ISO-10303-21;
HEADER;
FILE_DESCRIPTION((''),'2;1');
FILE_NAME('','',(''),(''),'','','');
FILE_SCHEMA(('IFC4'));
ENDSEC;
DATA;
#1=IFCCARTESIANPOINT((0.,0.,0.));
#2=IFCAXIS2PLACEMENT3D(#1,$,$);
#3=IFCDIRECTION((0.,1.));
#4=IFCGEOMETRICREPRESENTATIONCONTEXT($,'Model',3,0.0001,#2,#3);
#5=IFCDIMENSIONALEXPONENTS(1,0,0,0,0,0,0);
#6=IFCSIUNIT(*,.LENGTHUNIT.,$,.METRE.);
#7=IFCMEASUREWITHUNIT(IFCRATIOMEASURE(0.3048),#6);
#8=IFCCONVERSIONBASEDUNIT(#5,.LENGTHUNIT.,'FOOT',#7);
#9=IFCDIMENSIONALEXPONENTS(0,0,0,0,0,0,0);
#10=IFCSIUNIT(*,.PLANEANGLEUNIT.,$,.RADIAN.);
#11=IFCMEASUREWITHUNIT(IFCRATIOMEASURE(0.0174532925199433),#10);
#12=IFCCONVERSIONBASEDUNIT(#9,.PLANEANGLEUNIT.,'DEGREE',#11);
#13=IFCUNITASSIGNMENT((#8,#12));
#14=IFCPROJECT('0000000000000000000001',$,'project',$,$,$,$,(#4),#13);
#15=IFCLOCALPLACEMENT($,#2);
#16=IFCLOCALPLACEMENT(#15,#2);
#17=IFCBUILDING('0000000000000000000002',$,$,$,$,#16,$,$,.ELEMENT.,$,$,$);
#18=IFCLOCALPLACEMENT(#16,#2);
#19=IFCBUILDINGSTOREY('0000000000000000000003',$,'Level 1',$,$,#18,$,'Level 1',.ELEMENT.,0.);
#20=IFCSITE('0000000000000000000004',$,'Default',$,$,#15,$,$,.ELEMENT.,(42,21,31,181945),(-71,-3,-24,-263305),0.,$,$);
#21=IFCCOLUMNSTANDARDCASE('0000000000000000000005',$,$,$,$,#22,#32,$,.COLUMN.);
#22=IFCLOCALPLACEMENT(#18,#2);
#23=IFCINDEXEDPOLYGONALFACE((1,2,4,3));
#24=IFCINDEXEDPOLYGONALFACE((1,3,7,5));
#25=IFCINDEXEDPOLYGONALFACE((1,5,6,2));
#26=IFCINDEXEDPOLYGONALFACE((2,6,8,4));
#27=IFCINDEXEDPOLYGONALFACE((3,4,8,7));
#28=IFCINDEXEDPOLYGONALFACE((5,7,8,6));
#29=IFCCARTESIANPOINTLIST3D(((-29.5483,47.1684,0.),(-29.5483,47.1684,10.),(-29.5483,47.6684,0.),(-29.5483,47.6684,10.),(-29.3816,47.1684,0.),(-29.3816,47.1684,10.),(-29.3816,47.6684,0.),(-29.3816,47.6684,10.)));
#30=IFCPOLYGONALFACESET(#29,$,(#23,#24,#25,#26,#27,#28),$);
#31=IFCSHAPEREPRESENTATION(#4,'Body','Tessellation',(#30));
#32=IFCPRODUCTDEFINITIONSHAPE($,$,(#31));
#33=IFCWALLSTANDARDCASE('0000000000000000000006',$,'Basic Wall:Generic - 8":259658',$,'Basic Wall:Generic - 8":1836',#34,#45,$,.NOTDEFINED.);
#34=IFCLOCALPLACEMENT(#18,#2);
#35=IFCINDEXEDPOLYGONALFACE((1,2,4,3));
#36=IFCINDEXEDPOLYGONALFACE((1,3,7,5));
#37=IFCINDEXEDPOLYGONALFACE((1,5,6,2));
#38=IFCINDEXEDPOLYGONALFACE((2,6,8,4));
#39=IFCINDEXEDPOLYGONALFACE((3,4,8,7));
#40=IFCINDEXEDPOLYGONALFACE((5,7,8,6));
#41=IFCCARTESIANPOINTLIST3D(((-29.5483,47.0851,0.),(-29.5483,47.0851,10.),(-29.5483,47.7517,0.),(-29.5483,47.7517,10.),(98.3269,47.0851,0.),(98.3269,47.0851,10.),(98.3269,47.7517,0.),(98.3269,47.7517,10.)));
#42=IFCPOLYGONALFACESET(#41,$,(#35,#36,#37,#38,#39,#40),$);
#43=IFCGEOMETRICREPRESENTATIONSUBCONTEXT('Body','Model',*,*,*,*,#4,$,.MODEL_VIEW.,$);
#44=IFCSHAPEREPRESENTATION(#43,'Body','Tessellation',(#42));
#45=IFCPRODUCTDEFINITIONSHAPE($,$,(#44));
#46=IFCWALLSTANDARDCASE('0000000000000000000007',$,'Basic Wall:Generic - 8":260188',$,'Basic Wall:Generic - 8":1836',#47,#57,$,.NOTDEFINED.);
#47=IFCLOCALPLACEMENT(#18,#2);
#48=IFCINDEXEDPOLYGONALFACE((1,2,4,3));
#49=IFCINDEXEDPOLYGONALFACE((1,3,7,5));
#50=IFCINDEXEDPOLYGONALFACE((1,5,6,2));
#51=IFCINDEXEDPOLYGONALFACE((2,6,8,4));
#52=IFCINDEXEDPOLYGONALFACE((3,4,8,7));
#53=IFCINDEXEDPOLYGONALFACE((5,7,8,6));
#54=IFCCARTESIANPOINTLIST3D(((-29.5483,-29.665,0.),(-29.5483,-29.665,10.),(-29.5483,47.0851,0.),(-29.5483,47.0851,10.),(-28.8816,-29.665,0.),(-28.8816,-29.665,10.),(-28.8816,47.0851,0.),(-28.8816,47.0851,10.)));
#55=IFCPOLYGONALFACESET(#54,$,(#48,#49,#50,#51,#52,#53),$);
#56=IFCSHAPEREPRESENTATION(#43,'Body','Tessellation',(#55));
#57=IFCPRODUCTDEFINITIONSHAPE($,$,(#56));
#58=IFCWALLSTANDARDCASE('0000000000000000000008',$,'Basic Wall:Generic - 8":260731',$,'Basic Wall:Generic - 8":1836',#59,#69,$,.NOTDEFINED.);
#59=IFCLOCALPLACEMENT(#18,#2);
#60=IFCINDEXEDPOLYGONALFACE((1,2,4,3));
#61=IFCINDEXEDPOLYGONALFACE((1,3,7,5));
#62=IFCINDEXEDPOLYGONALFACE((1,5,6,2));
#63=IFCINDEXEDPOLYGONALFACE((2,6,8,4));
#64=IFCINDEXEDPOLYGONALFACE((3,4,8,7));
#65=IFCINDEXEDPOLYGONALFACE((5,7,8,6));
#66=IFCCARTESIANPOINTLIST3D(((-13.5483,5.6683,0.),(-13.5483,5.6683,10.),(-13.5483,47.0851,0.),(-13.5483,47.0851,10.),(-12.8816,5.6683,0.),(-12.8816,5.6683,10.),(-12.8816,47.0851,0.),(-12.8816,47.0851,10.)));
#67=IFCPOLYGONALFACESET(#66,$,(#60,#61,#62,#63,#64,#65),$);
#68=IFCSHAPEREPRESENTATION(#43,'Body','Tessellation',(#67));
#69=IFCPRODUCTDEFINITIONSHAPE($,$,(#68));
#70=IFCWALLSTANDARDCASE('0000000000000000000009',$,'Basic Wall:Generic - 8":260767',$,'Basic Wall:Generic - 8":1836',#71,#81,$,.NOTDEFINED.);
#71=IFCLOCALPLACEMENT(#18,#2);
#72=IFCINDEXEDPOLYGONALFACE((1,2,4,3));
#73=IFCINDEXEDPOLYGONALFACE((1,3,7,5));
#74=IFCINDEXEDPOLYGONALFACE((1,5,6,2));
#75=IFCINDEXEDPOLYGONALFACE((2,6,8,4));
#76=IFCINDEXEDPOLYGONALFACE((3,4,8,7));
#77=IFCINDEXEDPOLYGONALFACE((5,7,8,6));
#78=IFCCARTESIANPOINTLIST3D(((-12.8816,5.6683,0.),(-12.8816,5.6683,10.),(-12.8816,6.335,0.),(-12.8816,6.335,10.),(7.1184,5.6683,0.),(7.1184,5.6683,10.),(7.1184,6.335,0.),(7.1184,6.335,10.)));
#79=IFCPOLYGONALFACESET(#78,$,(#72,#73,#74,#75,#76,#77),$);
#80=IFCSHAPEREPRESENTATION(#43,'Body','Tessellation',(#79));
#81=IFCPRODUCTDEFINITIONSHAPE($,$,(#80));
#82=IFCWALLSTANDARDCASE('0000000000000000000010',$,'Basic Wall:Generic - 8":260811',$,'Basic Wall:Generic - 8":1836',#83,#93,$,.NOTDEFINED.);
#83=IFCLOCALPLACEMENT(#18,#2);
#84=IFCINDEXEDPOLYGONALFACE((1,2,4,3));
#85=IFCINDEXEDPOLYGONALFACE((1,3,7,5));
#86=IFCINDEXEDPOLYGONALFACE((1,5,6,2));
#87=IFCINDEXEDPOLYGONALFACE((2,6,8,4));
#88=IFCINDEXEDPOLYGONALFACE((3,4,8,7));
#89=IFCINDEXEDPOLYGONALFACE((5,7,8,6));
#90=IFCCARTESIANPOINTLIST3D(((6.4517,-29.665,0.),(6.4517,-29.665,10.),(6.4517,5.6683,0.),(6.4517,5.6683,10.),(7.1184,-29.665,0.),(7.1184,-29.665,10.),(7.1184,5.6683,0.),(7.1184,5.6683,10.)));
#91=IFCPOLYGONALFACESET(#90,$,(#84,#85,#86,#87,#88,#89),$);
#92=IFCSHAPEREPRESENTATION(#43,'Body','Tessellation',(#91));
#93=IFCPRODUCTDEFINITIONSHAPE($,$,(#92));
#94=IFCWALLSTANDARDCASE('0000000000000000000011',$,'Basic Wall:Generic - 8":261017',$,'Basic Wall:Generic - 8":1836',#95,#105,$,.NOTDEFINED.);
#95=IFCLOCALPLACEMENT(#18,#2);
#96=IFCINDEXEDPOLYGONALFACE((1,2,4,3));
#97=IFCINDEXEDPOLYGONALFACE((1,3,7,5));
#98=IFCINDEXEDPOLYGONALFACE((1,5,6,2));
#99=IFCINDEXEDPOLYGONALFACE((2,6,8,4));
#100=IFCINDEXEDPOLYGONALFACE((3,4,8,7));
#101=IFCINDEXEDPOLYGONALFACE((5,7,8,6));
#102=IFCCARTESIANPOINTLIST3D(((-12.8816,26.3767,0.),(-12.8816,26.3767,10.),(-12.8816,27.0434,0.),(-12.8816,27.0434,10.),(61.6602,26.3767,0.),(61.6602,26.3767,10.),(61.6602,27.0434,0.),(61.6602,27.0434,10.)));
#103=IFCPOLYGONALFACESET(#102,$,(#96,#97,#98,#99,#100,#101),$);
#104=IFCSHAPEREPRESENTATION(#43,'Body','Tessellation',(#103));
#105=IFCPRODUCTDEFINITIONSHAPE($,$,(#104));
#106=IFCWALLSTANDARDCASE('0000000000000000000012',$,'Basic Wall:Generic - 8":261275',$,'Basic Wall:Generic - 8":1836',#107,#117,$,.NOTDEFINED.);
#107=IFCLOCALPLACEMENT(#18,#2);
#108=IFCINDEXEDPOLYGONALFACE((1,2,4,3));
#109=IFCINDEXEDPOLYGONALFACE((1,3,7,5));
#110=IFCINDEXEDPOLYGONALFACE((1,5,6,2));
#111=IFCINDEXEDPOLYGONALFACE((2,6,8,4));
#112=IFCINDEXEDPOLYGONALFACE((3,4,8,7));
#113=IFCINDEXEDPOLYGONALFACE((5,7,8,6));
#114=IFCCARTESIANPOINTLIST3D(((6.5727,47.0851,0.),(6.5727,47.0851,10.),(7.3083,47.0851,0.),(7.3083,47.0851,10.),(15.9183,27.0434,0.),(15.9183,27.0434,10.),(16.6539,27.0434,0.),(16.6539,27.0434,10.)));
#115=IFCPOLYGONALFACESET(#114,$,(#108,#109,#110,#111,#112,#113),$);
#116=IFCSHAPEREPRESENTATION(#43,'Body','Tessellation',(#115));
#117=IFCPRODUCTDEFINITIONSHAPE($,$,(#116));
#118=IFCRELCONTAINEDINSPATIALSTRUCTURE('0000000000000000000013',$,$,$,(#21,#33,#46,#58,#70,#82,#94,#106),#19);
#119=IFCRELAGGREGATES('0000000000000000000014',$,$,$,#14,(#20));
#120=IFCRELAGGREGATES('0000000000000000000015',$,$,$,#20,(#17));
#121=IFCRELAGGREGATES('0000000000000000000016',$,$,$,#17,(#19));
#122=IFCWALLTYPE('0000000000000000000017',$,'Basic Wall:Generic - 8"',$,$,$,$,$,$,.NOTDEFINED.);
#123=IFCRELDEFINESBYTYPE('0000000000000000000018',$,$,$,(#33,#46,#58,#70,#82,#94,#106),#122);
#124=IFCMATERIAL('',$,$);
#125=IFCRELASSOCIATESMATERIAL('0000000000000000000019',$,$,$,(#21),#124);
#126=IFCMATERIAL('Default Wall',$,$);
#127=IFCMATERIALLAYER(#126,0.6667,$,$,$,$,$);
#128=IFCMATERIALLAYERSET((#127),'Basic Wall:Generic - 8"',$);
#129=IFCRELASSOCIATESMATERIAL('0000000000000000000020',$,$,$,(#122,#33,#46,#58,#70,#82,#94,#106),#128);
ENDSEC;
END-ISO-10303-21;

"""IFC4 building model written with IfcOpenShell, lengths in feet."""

from ifc_helpers import new_model, entity, si_unit, converted_unit, direction, frame, frame_2d, origin, place, context, subcontext, project, spatial, polyline, rectangle, outline, extrude, material, layer, layer_set, layer_usage, type_object, element, save


model = new_model("IFC4")

# Units and contexts
model_context = context("Model", 3, precision=0.0001, world=origin(), true_north=direction((0.0, 1.0)))
body_context = subcontext(model_context, "Body", "Model", "MODEL_VIEW")
ifc_project = project(units=[converted_unit("LENGTHUNIT", "FOOT", entity("IfcRatioMeasure", 0.3048), si_unit("LENGTHUNIT", "METRE"), dimensions=[1, 0, 0, 0, 0, 0, 0]), converted_unit("PLANEANGLEUNIT", "DEGREE", entity("IfcRatioMeasure", 0.0174532925199433), si_unit("PLANEANGLEUNIT", "RADIAN"), dimensions=[0, 0, 0, 0, 0, 0, 0])], contexts=[model_context])

# Site, building, storey
site_placement = place(None, origin())
site = spatial("IfcSite", under=ifc_project, at=site_placement, Name="Default", CompositionType="ELEMENT", RefLatitude=(42, 21, 31, 181945), RefLongitude=(-71, -3, -24, -263305), RefElevation=0.0)
building_placement = place(site_placement, origin())
building = spatial("IfcBuilding", under=site, at=building_placement, CompositionType="ELEMENT")
storey_placement = place(building_placement, origin())
storey = spatial("IfcBuildingStorey", under=building, at=storey_placement, Name="Level 1", LongName="Level 1", CompositionType="ELEMENT", Elevation=0.0)

# Column
ifc_material_1 = material(Name="")
wall_1_placement = place(storey_placement, frame((-29.5483, 47.4184, 0.0)))
for number, where, z_axis, x_axis in (
    (1, (0.0833, 0.0, 0.0), (0.0, 0.0, 1.0), (1.0, 0.0, 0.0)),
):
    element("IfcColumnStandardCase", number, at=place(wall_1_placement, frame(where, z_axis=z_axis, x_axis=x_axis)), inside=storey, material=ifc_material_1, PredefinedType="COLUMN", context=model_context, shape_type="SweptSolid", body=[
        extrude(rectangle(XDim=0.1667, YDim=0.5), origin(), (0.0, 0.0, 1.0), 10.0),
    ])

# Walls
ifc_material_2 = material(Name="Default Wall")
ifc_layer = layer(ifc_material_2, 0.6667)
ifc_layer_set = layer_set([ifc_layer], Name="Basic Wall:Generic - 8\"")
ifc_layer_usage_1 = layer_usage(ifc_layer_set, "AXIS2", "NEGATIVE", 0.3333)
wall_type = type_object("IfcWallType", Name="Basic Wall:Generic - 8\"", PredefinedType="NOTDEFINED", material=ifc_layer_set)
element("IfcWallStandardCase", 2, at=wall_1_placement, inside=storey, type_object=wall_type, material=ifc_layer_usage_1, Name="Basic Wall:Generic - 8\":259658", ObjectType="Basic Wall:Generic - 8\":1836", PredefinedType="NOTDEFINED", context=body_context, shape_type="SweptSolid", body=[
    extrude(rectangle(XDim=127.8752, YDim=0.6667, at=frame_2d((63.9376, 0.0), x_axis=(-1.0, 0.0))), origin(), (0.0, 0.0, 1.0), 10.0),
])
ifc_layer_usage_2 = layer_usage(ifc_layer_set, "AXIS2", "NEGATIVE", 0.3333)
wall_2_placement = place(storey_placement, frame((-29.215, 47.0851, 0.0), z_axis=(0.0, 0.0, 1.0), x_axis=(0.0, -1.0, 0.0)))
element("IfcWallStandardCase", 3, at=wall_2_placement, inside=storey, type_object=wall_type, material=ifc_layer_usage_2, Name="Basic Wall:Generic - 8\":260188", ObjectType="Basic Wall:Generic - 8\":1836", PredefinedType="NOTDEFINED", context=body_context, shape_type="SweptSolid", body=[
    extrude(rectangle(XDim=76.7501, YDim=0.6667, at=frame_2d((38.375, 0.0), x_axis=(-1.0, 0.0))), origin(), (0.0, 0.0, 1.0), 10.0),
])
ifc_layer_usage_3 = layer_usage(ifc_layer_set, "AXIS2", "NEGATIVE", 0.3333)
wall_3_placement = place(storey_placement, frame((-13.215, 47.0851, 0.0), z_axis=(0.0, 0.0, 1.0), x_axis=(0.0, -1.0, 0.0)))
element("IfcWallStandardCase", 4, at=wall_3_placement, inside=storey, type_object=wall_type, material=ifc_layer_usage_3, Name="Basic Wall:Generic - 8\":260731", ObjectType="Basic Wall:Generic - 8\":1836", PredefinedType="NOTDEFINED", context=body_context, shape_type="SweptSolid", body=[
    extrude(rectangle(XDim=41.4167, YDim=0.6667, at=frame_2d((20.7084, 0.0), x_axis=(-1.0, 0.0))), origin(), (0.0, 0.0, 1.0), 10.0),
])
ifc_layer_usage_4 = layer_usage(ifc_layer_set, "AXIS2", "NEGATIVE", 0.3333)
wall_4_placement = place(storey_placement, frame((-12.8816, 6.0017, 0.0)))
element("IfcWallStandardCase", 5, at=wall_4_placement, inside=storey, type_object=wall_type, material=ifc_layer_usage_4, Name="Basic Wall:Generic - 8\":260767", ObjectType="Basic Wall:Generic - 8\":1836", PredefinedType="NOTDEFINED", context=body_context, shape_type="SweptSolid", body=[
    extrude(rectangle(XDim=20.0, YDim=0.6667, at=frame_2d((10.0, 0.0), x_axis=(-1.0, 0.0))), origin(), (0.0, 0.0, 1.0), 10.0),
])
ifc_layer_usage_5 = layer_usage(ifc_layer_set, "AXIS2", "NEGATIVE", 0.3333)
wall_5_placement = place(storey_placement, frame((6.785, 5.6683, 0.0), z_axis=(0.0, 0.0, 1.0), x_axis=(0.0, -1.0, 0.0)))
element("IfcWallStandardCase", 6, at=wall_5_placement, inside=storey, type_object=wall_type, material=ifc_layer_usage_5, Name="Basic Wall:Generic - 8\":260811", ObjectType="Basic Wall:Generic - 8\":1836", PredefinedType="NOTDEFINED", context=body_context, shape_type="SweptSolid", body=[
    extrude(rectangle(XDim=35.3333, YDim=0.6667, at=frame_2d((17.6667, 0.0), x_axis=(-1.0, 0.0))), origin(), (0.0, 0.0, 1.0), 10.0),
])
ifc_layer_usage_6 = layer_usage(ifc_layer_set, "AXIS2", "NEGATIVE", 0.3333)
wall_6_placement = place(storey_placement, frame((-12.8816, 26.71, 0.0)))
element("IfcWallStandardCase", 7, at=wall_6_placement, inside=storey, type_object=wall_type, material=ifc_layer_usage_6, Name="Basic Wall:Generic - 8\":261017", ObjectType="Basic Wall:Generic - 8\":1836", PredefinedType="NOTDEFINED", context=body_context, shape_type="SweptSolid", body=[
    extrude(rectangle(XDim=74.5419, YDim=0.6667, at=frame_2d((37.2709, 0.0), x_axis=(-1.0, 0.0))), origin(), (0.0, 0.0, 1.0), 10.0),
])
ifc_layer_usage_7 = layer_usage(ifc_layer_set, "AXIS2", "NEGATIVE", 0.3333)
wall_7_placement = place(storey_placement, frame((6.8748, 47.226, 0.0), z_axis=(0.0, 0.0, 1.0), x_axis=(0.422618, -0.906308, 0.0)))
element("IfcWallStandardCase", 8, at=wall_7_placement, inside=storey, type_object=wall_type, material=ifc_layer_usage_7, Name="Basic Wall:Generic - 8\":261275", ObjectType="Basic Wall:Generic - 8\":1836", PredefinedType="NOTDEFINED", context=body_context, shape_type="SweptSolid", body=[
    extrude(outline(polyline([(22.1136, -0.3333), (22.4244, 0.3333), (0.3109, 0.3333), (0.0, -0.3333), (22.1136, -0.3333)])), origin(), (0.0, 0.0, 1.0), 10.0),
])

save(model, "model.ifc")
